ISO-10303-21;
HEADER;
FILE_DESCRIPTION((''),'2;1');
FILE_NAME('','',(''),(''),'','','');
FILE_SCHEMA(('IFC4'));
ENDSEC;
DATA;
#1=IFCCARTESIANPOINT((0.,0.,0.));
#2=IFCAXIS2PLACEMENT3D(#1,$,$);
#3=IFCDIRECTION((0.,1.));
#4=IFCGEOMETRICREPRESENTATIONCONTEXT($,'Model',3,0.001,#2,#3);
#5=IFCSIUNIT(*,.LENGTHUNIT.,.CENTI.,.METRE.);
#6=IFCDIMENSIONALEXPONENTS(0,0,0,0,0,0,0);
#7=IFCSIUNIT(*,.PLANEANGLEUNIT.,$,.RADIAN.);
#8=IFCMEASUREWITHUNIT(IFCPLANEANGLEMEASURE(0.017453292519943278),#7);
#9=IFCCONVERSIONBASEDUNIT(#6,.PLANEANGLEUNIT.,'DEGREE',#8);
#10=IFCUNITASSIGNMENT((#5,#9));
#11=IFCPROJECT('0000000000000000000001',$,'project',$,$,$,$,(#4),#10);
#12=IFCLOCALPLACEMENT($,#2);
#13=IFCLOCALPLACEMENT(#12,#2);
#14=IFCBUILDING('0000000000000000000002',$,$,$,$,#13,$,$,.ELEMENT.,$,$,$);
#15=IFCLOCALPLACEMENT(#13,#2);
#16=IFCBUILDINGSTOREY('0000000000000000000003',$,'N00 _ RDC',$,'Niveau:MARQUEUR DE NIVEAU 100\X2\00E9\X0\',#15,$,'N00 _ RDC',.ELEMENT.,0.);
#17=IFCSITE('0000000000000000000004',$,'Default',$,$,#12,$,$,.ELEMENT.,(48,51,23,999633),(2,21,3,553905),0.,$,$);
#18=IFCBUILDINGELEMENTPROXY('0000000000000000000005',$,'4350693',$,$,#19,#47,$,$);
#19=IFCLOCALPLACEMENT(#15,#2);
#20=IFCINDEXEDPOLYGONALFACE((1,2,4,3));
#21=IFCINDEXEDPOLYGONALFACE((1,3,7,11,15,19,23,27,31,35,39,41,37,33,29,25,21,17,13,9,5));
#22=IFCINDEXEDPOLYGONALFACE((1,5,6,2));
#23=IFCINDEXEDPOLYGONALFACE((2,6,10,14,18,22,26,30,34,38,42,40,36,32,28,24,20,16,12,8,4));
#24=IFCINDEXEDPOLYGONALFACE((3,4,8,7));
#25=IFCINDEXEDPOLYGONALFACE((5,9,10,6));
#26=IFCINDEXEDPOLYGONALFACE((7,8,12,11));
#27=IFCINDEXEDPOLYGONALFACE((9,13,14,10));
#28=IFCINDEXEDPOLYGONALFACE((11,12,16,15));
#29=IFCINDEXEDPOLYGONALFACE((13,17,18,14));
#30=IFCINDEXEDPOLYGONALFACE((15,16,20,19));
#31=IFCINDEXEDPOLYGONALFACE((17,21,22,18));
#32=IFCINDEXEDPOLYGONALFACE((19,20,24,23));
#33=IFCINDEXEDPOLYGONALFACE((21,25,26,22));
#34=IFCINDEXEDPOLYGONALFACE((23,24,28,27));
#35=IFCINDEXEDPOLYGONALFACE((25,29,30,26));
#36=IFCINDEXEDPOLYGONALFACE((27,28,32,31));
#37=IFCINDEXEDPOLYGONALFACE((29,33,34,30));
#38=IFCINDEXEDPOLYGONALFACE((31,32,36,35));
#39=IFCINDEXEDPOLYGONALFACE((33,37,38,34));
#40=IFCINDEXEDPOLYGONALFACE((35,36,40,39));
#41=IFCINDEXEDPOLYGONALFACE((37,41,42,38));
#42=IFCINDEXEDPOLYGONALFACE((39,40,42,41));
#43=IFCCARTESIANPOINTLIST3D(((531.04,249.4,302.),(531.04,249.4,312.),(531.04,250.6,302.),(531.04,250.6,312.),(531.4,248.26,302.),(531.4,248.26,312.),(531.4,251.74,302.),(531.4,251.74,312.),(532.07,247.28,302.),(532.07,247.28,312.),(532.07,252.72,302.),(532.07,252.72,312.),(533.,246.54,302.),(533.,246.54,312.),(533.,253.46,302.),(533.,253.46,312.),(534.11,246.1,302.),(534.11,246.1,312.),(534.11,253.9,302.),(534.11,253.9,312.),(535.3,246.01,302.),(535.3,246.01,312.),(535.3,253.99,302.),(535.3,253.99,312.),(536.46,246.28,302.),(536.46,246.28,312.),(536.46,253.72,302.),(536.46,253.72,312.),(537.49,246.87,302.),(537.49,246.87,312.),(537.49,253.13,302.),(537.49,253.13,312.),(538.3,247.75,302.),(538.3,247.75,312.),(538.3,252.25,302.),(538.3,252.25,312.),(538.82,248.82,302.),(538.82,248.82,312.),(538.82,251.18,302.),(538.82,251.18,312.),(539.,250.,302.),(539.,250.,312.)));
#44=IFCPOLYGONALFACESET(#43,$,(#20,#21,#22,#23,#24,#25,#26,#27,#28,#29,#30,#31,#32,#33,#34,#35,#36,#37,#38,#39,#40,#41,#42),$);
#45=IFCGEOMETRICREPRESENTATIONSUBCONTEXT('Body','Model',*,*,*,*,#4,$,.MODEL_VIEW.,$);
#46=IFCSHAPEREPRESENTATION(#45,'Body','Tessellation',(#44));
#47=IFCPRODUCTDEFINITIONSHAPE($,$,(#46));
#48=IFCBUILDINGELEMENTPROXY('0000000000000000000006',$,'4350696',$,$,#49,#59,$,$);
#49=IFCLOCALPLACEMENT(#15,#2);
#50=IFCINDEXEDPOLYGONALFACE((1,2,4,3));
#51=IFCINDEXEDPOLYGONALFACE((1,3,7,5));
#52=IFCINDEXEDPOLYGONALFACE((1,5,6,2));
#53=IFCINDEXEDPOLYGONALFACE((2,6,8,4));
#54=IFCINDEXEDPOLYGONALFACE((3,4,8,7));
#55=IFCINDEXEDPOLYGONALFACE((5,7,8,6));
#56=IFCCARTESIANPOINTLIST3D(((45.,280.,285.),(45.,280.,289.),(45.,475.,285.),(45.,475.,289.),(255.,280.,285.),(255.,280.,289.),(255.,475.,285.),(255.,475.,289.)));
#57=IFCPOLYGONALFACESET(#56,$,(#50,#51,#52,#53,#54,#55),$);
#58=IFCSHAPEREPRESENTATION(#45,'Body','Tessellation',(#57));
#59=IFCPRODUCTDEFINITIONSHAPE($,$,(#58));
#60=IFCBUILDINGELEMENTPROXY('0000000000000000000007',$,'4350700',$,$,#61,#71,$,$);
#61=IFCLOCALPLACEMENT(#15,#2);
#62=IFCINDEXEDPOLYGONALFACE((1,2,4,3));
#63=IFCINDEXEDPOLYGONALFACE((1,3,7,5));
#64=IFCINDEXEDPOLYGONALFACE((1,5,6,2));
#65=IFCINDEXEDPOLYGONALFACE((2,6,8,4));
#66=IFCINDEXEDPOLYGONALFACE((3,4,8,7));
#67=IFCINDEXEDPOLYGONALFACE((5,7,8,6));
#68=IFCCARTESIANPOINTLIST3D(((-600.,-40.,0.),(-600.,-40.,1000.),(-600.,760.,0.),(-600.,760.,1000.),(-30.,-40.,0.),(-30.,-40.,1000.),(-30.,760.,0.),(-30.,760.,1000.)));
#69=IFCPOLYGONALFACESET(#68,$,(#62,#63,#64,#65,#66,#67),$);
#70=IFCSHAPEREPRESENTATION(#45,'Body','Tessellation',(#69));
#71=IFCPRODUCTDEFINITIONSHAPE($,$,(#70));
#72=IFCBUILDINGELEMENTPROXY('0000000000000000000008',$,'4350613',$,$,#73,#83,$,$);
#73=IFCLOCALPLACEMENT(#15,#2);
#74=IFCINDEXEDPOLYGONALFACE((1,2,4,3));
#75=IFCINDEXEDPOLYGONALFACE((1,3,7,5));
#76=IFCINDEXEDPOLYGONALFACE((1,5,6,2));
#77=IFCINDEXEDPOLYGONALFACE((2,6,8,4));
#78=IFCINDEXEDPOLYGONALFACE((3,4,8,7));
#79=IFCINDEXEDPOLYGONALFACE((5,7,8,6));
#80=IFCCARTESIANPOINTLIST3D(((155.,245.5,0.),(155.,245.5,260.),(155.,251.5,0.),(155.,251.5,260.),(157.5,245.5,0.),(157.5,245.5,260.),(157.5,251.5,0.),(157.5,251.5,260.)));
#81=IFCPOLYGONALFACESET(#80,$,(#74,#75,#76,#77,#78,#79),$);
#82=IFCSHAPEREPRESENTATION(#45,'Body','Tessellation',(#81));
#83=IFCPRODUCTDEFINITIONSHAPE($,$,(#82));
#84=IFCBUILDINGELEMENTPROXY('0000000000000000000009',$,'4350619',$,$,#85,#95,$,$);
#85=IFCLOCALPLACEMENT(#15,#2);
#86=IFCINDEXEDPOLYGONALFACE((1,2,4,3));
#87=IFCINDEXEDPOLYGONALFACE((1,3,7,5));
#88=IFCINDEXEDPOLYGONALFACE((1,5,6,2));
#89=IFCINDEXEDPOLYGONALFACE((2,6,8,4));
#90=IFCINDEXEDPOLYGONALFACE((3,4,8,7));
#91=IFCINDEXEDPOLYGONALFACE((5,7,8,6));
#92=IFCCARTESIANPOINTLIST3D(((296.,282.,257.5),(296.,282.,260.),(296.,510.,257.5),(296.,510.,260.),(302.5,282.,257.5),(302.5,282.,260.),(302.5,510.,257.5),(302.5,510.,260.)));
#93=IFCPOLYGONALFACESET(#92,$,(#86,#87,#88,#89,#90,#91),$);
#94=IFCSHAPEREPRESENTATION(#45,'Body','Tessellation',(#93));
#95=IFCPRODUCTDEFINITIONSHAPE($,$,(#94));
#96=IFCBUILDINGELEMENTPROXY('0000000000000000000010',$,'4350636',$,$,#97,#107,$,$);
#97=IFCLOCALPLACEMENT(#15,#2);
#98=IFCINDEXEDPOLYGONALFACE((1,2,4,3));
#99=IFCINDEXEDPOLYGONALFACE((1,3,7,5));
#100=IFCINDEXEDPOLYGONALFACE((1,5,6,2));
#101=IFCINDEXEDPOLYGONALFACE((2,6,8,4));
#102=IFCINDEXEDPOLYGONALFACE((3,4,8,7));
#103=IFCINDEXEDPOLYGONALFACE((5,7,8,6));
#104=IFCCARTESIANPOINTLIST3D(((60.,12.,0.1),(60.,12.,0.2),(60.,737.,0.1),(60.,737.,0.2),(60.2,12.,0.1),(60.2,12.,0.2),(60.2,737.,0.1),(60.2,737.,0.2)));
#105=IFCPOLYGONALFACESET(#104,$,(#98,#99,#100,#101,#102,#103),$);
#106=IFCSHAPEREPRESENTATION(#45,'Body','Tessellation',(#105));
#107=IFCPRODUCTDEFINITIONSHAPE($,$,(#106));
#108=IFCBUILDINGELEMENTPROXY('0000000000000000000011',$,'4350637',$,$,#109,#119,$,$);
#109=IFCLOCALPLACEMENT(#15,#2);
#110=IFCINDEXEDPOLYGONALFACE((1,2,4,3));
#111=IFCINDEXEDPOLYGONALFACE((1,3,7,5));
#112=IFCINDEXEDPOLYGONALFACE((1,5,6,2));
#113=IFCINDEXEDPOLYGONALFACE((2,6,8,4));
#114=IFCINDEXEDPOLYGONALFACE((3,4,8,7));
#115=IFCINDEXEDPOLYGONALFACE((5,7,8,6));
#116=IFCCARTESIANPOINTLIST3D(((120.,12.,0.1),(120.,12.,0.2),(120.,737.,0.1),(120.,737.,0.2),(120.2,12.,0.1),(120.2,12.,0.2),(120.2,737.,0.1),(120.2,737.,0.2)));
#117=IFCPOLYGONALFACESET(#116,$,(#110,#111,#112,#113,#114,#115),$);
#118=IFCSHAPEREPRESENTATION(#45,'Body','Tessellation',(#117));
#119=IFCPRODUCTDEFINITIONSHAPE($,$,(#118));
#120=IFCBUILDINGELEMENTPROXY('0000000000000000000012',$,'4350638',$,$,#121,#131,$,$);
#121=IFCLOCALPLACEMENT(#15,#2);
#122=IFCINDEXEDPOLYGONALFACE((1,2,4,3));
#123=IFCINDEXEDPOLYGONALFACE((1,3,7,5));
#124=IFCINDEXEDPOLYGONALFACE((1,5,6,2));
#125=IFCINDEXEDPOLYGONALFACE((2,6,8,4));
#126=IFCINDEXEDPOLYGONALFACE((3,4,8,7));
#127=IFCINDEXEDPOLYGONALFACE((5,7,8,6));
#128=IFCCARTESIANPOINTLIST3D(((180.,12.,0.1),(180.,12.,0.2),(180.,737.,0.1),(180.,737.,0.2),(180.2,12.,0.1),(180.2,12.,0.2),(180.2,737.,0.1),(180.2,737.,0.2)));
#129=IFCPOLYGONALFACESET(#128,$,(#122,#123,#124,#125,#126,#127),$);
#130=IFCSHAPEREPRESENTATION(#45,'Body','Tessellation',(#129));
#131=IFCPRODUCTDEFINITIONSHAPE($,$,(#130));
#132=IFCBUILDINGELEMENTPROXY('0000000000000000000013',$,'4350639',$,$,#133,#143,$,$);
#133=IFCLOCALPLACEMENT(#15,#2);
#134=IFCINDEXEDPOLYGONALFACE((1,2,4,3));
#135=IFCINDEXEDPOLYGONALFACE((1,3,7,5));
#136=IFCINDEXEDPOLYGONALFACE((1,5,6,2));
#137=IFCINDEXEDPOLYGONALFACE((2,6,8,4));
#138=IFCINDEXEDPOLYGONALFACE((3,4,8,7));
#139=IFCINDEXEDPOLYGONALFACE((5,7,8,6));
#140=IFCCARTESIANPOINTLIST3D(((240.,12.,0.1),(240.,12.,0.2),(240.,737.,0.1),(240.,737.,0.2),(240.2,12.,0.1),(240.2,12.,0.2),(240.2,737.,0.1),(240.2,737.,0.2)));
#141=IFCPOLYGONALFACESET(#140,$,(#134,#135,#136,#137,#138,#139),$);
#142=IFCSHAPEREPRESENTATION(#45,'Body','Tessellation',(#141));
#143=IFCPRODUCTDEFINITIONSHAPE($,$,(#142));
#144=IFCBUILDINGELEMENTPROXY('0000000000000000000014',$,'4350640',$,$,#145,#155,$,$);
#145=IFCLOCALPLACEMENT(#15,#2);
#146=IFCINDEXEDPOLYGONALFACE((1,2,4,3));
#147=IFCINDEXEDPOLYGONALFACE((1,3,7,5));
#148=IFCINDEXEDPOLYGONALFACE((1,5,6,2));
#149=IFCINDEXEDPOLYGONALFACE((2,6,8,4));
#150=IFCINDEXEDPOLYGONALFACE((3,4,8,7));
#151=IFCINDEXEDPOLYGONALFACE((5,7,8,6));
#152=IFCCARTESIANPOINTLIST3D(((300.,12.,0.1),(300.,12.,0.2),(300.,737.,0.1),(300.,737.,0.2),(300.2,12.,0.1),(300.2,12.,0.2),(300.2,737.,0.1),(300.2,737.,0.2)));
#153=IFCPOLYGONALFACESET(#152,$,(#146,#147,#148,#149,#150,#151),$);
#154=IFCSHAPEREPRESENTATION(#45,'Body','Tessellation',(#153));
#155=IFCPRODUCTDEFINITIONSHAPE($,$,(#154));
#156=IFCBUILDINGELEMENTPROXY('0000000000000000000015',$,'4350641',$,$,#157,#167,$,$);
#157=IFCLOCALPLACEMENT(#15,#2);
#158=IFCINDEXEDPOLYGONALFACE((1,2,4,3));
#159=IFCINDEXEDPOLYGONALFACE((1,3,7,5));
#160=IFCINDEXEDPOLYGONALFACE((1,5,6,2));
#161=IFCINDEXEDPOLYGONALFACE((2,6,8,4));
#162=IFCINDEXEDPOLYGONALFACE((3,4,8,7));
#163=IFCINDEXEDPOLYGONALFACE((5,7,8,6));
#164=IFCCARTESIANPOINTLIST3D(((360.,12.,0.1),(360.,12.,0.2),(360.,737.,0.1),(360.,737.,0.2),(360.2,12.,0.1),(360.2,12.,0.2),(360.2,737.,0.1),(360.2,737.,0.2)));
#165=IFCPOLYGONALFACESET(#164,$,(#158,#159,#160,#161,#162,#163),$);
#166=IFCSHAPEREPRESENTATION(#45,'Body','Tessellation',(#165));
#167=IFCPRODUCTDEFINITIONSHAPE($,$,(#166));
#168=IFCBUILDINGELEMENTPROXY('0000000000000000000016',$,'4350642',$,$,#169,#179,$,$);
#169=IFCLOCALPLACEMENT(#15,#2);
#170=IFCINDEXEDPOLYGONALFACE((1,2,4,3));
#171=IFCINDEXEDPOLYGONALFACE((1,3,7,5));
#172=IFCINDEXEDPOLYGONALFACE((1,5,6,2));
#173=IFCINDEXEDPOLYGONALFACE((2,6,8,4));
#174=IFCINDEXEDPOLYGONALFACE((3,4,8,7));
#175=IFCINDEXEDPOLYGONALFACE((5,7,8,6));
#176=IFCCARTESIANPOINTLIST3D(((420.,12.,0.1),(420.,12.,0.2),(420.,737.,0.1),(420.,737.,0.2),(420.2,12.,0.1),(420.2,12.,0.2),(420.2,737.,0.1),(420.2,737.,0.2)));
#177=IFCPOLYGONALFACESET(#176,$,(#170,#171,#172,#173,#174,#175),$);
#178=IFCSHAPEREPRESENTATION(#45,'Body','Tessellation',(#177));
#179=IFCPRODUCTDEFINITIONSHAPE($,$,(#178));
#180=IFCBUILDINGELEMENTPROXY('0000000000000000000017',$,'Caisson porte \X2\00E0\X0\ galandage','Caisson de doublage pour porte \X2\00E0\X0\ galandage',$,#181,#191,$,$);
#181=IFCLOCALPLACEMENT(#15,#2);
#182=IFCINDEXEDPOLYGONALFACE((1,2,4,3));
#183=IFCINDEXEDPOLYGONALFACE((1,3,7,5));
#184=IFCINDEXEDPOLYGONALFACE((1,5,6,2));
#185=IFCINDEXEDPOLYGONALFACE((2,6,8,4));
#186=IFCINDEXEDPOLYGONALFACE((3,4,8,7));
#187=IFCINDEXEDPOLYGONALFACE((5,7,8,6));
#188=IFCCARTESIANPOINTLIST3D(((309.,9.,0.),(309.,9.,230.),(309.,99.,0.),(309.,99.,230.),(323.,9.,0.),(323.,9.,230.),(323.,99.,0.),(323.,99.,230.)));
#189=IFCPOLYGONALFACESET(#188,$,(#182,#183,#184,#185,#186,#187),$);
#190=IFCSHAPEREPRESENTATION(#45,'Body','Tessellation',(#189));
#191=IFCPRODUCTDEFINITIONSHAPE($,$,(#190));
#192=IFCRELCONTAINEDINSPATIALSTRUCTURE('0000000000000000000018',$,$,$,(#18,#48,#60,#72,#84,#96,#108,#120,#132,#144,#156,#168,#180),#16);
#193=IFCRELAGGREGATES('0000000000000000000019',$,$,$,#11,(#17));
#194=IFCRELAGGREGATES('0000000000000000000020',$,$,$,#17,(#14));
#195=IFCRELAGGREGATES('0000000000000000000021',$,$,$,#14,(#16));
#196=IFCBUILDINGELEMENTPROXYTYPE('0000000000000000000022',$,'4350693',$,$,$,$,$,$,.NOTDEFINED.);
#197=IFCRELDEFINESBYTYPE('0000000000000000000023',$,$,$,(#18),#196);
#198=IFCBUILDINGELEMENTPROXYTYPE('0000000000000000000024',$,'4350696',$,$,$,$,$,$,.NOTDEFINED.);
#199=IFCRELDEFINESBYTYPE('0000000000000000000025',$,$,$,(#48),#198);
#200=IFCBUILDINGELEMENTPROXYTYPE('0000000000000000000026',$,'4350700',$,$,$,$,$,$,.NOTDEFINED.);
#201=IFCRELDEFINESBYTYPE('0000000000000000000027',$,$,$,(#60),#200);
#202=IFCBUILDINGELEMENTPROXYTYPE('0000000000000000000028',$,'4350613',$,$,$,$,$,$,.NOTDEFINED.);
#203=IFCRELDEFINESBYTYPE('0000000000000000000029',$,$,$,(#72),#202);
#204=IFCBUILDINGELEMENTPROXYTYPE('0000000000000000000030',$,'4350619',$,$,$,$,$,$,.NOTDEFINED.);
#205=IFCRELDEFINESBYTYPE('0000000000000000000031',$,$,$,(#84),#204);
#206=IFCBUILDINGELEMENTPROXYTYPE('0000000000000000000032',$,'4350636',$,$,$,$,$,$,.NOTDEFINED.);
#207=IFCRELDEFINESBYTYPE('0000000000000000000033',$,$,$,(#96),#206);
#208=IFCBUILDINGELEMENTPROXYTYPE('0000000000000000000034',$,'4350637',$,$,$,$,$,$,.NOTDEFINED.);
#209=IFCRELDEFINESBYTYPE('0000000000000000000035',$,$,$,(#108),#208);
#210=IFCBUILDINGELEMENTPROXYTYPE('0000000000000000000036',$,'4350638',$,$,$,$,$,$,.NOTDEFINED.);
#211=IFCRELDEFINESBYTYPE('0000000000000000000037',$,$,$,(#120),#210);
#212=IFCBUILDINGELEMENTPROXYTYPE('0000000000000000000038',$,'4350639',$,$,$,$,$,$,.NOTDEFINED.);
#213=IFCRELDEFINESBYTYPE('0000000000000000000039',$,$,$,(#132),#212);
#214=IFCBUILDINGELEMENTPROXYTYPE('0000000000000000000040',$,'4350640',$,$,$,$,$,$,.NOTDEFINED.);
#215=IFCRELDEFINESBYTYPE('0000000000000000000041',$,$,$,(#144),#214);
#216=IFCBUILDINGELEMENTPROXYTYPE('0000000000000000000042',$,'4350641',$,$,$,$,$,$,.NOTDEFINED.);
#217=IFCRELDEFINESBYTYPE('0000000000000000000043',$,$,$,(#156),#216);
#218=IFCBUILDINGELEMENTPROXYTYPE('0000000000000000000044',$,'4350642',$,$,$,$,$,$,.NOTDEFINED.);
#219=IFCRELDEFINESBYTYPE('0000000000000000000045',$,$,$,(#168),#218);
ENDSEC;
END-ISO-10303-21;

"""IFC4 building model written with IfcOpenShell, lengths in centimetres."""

from ifc_helpers import new_model, entity, si_unit, converted_unit, direction, frame, frame_2d, origin, origin_with_axes, origin_2d_with_axis, place, context, subcontext, project, spatial, rectangle, circle, extrude, type_object, element, save


model = new_model("IFC4")

# Units and contexts
model_context = context("Model", 3, precision=0.001, world=origin(), true_north=direction((0.0, 1.0)))
body_context = subcontext(model_context, "Body", "Model", "MODEL_VIEW")
ifc_project = project(units=[si_unit("LENGTHUNIT", "METRE", prefix="CENTI"), converted_unit("PLANEANGLEUNIT", "DEGREE", entity("IfcPlaneAngleMeasure", 0.017453292519943278), si_unit("PLANEANGLEUNIT", "RADIAN"), dimensions=[0, 0, 0, 0, 0, 0, 0])], contexts=[model_context])

# Site, building, storey
site_placement = place(None, origin())
site = spatial("IfcSite", under=ifc_project, at=site_placement, Name="Default", CompositionType="ELEMENT", RefLatitude=(48, 51, 23, 999633), RefLongitude=(2, 21, 3, 553905), RefElevation=0.0)
building_placement = place(site_placement, origin())
building = spatial("IfcBuilding", under=site, at=building_placement, CompositionType="ELEMENT")
storey_placement = place(building_placement, origin())
storey = spatial("IfcBuildingStorey", under=building, at=storey_placement, Name="N00 _ RDC", ObjectType="Niveau:MARQUEUR DE NIVEAU 100é", LongName="N00 _ RDC", CompositionType="ELEMENT", Elevation=0.0)

# Building element proxies
building_element_proxy_type_1 = type_object("IfcBuildingElementProxyType", Name="4350693", PredefinedType="NOTDEFINED")
proxy_1_placement = place(storey_placement, origin())
element("IfcBuildingElementProxy", 1, at=proxy_1_placement, inside=storey, type_object=building_element_proxy_type_1, Name="4350693", context=body_context, shape_type="SweptSolid", body=[
    extrude(circle(Radius=4.0, at=origin_2d_with_axis()), frame((535.0, 250.0, 302.0)), (0.0, 0.0, 1.0), 10.0),
])
building_element_proxy_type_2 = type_object("IfcBuildingElementProxyType", Name="4350696", PredefinedType="NOTDEFINED")
proxy_2_placement = place(storey_placement, origin())
element("IfcBuildingElementProxy", 2, at=proxy_2_placement, inside=storey, type_object=building_element_proxy_type_2, Name="4350696", context=body_context, shape_type="SweptSolid", body=[
    extrude(rectangle(XDim=210.0, YDim=195.0, at=frame_2d((0.0, 0.0), x_axis=(1.0, 0.0))), frame((150.0, 377.5, 285.0)), (0.0, 0.0, 1.0), 4.0),
])
building_element_proxy_type_3 = type_object("IfcBuildingElementProxyType", Name="4350700", PredefinedType="NOTDEFINED")
proxy_3_placement = place(storey_placement, origin())
element("IfcBuildingElementProxy", 3, at=proxy_3_placement, inside=storey, type_object=building_element_proxy_type_3, Name="4350700", context=body_context, shape_type="SweptSolid", body=[
    extrude(rectangle(XDim=570.0, YDim=800.0, at=origin_2d_with_axis()), frame((-315.0, 360.0, 0.0)), (0.0, 0.0, 1.0), 1000.0),
])
building_element_proxy_type_4 = type_object("IfcBuildingElementProxyType", Name="4350613", PredefinedType="NOTDEFINED")
proxy_4_placement = place(storey_placement, origin())
element("IfcBuildingElementProxy", 4, at=proxy_4_placement, inside=storey, type_object=building_element_proxy_type_4, Name="4350613", context=body_context, shape_type="SweptSolid", body=[
    extrude(rectangle(XDim=2.5, YDim=6.0, at=frame_2d((0.0, 0.0), x_axis=(1.0, 0.0))), frame((156.25, 248.5, 0.0)), (0.0, 0.0, 1.0), 260.0),
])
building_element_proxy_type_5 = type_object("IfcBuildingElementProxyType", Name="4350619", PredefinedType="NOTDEFINED")
proxy_5_placement = place(storey_placement, origin())
element("IfcBuildingElementProxy", 5, at=proxy_5_placement, inside=storey, type_object=building_element_proxy_type_5, Name="4350619", context=body_context, shape_type="SweptSolid", body=[
    extrude(rectangle(XDim=6.5, YDim=228.0, at=frame_2d((0.0, 0.0), x_axis=(1.0, 0.0))), frame((299.25, 396.0, 257.5)), (0.0, 0.0, 1.0), 2.5),
])
building_element_proxy_type_6 = type_object("IfcBuildingElementProxyType", Name="4350636", PredefinedType="NOTDEFINED")
proxy_6_placement = place(storey_placement, origin())
element("IfcBuildingElementProxy", 6, at=proxy_6_placement, inside=storey, type_object=building_element_proxy_type_6, Name="4350636", context=body_context, shape_type="SweptSolid", body=[
    extrude(rectangle(XDim=0.2, YDim=725.0, at=frame_2d((0.0, 0.0), x_axis=(1.0, 0.0))), frame((60.1, 374.5, 0.1)), (0.0, 0.0, 1.0), 0.1),
])
building_element_proxy_type_7 = type_object("IfcBuildingElementProxyType", Name="4350637", PredefinedType="NOTDEFINED")
proxy_7_placement = place(storey_placement, origin())
element("IfcBuildingElementProxy", 7, at=proxy_7_placement, inside=storey, type_object=building_element_proxy_type_7, Name="4350637", context=body_context, shape_type="SweptSolid", body=[
    extrude(rectangle(XDim=0.2, YDim=725.0, at=frame_2d((0.0, 0.0), x_axis=(1.0, 0.0))), frame((120.1, 374.5, 0.1)), (0.0, 0.0, 1.0), 0.1),
])
building_element_proxy_type_8 = type_object("IfcBuildingElementProxyType", Name="4350638", PredefinedType="NOTDEFINED")
proxy_8_placement = place(storey_placement, origin())
element("IfcBuildingElementProxy", 8, at=proxy_8_placement, inside=storey, type_object=building_element_proxy_type_8, Name="4350638", context=body_context, shape_type="SweptSolid", body=[
    extrude(rectangle(XDim=0.2, YDim=725.0, at=origin_2d_with_axis()), frame((180.1, 374.5, 0.1)), (0.0, 0.0, 1.0), 0.1),
])
building_element_proxy_type_9 = type_object("IfcBuildingElementProxyType", Name="4350639", PredefinedType="NOTDEFINED")
proxy_9_placement = place(storey_placement, origin())
element("IfcBuildingElementProxy", 9, at=proxy_9_placement, inside=storey, type_object=building_element_proxy_type_9, Name="4350639", context=body_context, shape_type="SweptSolid", body=[
    extrude(rectangle(XDim=0.2, YDim=725.0, at=frame_2d((0.0, 0.0), x_axis=(1.0, 0.0))), frame((240.1, 374.5, 0.1)), (0.0, 0.0, 1.0), 0.1),
])
building_element_proxy_type_10 = type_object("IfcBuildingElementProxyType", Name="4350640", PredefinedType="NOTDEFINED")
proxy_10_placement = place(storey_placement, origin())
element("IfcBuildingElementProxy", 10, at=proxy_10_placement, inside=storey, type_object=building_element_proxy_type_10, Name="4350640", context=body_context, shape_type="SweptSolid", body=[
    extrude(rectangle(XDim=0.2, YDim=725.0, at=origin_2d_with_axis()), frame((300.1, 374.5, 0.1)), (0.0, 0.0, 1.0), 0.1),
])
building_element_proxy_type_11 = type_object("IfcBuildingElementProxyType", Name="4350641", PredefinedType="NOTDEFINED")
proxy_11_placement = place(storey_placement, origin())
element("IfcBuildingElementProxy", 11, at=proxy_11_placement, inside=storey, type_object=building_element_proxy_type_11, Name="4350641", context=body_context, shape_type="SweptSolid", body=[
    extrude(rectangle(XDim=0.2, YDim=725.0, at=origin_2d_with_axis()), frame((360.1, 374.5, 0.1)), (0.0, 0.0, 1.0), 0.1),
])
building_element_proxy_type_12 = type_object("IfcBuildingElementProxyType", Name="4350642", PredefinedType="NOTDEFINED")
proxy_12_placement = place(storey_placement, origin())
element("IfcBuildingElementProxy", 12, at=proxy_12_placement, inside=storey, type_object=building_element_proxy_type_12, Name="4350642", context=body_context, shape_type="SweptSolid", body=[
    extrude(rectangle(XDim=0.2, YDim=725.0, at=origin_2d_with_axis()), frame((420.1, 374.5, 0.1)), (0.0, 0.0, 1.0), 0.1),
])
proxy_13_placement = place(storey_placement, origin_with_axes())
element("IfcBuildingElementProxy", 13, at=proxy_13_placement, inside=storey, Name="Caisson porte à galandage", Description="Caisson de doublage pour porte à galandage", context=body_context, shape_type="SweptSolid", body=[
    extrude(rectangle(XDim=14.0, YDim=90.0, at=frame_2d((316.0, 54.0))), origin(), (0.0, 0.0, 1.0), 230.0),
])

save(model, "model.ifc")
